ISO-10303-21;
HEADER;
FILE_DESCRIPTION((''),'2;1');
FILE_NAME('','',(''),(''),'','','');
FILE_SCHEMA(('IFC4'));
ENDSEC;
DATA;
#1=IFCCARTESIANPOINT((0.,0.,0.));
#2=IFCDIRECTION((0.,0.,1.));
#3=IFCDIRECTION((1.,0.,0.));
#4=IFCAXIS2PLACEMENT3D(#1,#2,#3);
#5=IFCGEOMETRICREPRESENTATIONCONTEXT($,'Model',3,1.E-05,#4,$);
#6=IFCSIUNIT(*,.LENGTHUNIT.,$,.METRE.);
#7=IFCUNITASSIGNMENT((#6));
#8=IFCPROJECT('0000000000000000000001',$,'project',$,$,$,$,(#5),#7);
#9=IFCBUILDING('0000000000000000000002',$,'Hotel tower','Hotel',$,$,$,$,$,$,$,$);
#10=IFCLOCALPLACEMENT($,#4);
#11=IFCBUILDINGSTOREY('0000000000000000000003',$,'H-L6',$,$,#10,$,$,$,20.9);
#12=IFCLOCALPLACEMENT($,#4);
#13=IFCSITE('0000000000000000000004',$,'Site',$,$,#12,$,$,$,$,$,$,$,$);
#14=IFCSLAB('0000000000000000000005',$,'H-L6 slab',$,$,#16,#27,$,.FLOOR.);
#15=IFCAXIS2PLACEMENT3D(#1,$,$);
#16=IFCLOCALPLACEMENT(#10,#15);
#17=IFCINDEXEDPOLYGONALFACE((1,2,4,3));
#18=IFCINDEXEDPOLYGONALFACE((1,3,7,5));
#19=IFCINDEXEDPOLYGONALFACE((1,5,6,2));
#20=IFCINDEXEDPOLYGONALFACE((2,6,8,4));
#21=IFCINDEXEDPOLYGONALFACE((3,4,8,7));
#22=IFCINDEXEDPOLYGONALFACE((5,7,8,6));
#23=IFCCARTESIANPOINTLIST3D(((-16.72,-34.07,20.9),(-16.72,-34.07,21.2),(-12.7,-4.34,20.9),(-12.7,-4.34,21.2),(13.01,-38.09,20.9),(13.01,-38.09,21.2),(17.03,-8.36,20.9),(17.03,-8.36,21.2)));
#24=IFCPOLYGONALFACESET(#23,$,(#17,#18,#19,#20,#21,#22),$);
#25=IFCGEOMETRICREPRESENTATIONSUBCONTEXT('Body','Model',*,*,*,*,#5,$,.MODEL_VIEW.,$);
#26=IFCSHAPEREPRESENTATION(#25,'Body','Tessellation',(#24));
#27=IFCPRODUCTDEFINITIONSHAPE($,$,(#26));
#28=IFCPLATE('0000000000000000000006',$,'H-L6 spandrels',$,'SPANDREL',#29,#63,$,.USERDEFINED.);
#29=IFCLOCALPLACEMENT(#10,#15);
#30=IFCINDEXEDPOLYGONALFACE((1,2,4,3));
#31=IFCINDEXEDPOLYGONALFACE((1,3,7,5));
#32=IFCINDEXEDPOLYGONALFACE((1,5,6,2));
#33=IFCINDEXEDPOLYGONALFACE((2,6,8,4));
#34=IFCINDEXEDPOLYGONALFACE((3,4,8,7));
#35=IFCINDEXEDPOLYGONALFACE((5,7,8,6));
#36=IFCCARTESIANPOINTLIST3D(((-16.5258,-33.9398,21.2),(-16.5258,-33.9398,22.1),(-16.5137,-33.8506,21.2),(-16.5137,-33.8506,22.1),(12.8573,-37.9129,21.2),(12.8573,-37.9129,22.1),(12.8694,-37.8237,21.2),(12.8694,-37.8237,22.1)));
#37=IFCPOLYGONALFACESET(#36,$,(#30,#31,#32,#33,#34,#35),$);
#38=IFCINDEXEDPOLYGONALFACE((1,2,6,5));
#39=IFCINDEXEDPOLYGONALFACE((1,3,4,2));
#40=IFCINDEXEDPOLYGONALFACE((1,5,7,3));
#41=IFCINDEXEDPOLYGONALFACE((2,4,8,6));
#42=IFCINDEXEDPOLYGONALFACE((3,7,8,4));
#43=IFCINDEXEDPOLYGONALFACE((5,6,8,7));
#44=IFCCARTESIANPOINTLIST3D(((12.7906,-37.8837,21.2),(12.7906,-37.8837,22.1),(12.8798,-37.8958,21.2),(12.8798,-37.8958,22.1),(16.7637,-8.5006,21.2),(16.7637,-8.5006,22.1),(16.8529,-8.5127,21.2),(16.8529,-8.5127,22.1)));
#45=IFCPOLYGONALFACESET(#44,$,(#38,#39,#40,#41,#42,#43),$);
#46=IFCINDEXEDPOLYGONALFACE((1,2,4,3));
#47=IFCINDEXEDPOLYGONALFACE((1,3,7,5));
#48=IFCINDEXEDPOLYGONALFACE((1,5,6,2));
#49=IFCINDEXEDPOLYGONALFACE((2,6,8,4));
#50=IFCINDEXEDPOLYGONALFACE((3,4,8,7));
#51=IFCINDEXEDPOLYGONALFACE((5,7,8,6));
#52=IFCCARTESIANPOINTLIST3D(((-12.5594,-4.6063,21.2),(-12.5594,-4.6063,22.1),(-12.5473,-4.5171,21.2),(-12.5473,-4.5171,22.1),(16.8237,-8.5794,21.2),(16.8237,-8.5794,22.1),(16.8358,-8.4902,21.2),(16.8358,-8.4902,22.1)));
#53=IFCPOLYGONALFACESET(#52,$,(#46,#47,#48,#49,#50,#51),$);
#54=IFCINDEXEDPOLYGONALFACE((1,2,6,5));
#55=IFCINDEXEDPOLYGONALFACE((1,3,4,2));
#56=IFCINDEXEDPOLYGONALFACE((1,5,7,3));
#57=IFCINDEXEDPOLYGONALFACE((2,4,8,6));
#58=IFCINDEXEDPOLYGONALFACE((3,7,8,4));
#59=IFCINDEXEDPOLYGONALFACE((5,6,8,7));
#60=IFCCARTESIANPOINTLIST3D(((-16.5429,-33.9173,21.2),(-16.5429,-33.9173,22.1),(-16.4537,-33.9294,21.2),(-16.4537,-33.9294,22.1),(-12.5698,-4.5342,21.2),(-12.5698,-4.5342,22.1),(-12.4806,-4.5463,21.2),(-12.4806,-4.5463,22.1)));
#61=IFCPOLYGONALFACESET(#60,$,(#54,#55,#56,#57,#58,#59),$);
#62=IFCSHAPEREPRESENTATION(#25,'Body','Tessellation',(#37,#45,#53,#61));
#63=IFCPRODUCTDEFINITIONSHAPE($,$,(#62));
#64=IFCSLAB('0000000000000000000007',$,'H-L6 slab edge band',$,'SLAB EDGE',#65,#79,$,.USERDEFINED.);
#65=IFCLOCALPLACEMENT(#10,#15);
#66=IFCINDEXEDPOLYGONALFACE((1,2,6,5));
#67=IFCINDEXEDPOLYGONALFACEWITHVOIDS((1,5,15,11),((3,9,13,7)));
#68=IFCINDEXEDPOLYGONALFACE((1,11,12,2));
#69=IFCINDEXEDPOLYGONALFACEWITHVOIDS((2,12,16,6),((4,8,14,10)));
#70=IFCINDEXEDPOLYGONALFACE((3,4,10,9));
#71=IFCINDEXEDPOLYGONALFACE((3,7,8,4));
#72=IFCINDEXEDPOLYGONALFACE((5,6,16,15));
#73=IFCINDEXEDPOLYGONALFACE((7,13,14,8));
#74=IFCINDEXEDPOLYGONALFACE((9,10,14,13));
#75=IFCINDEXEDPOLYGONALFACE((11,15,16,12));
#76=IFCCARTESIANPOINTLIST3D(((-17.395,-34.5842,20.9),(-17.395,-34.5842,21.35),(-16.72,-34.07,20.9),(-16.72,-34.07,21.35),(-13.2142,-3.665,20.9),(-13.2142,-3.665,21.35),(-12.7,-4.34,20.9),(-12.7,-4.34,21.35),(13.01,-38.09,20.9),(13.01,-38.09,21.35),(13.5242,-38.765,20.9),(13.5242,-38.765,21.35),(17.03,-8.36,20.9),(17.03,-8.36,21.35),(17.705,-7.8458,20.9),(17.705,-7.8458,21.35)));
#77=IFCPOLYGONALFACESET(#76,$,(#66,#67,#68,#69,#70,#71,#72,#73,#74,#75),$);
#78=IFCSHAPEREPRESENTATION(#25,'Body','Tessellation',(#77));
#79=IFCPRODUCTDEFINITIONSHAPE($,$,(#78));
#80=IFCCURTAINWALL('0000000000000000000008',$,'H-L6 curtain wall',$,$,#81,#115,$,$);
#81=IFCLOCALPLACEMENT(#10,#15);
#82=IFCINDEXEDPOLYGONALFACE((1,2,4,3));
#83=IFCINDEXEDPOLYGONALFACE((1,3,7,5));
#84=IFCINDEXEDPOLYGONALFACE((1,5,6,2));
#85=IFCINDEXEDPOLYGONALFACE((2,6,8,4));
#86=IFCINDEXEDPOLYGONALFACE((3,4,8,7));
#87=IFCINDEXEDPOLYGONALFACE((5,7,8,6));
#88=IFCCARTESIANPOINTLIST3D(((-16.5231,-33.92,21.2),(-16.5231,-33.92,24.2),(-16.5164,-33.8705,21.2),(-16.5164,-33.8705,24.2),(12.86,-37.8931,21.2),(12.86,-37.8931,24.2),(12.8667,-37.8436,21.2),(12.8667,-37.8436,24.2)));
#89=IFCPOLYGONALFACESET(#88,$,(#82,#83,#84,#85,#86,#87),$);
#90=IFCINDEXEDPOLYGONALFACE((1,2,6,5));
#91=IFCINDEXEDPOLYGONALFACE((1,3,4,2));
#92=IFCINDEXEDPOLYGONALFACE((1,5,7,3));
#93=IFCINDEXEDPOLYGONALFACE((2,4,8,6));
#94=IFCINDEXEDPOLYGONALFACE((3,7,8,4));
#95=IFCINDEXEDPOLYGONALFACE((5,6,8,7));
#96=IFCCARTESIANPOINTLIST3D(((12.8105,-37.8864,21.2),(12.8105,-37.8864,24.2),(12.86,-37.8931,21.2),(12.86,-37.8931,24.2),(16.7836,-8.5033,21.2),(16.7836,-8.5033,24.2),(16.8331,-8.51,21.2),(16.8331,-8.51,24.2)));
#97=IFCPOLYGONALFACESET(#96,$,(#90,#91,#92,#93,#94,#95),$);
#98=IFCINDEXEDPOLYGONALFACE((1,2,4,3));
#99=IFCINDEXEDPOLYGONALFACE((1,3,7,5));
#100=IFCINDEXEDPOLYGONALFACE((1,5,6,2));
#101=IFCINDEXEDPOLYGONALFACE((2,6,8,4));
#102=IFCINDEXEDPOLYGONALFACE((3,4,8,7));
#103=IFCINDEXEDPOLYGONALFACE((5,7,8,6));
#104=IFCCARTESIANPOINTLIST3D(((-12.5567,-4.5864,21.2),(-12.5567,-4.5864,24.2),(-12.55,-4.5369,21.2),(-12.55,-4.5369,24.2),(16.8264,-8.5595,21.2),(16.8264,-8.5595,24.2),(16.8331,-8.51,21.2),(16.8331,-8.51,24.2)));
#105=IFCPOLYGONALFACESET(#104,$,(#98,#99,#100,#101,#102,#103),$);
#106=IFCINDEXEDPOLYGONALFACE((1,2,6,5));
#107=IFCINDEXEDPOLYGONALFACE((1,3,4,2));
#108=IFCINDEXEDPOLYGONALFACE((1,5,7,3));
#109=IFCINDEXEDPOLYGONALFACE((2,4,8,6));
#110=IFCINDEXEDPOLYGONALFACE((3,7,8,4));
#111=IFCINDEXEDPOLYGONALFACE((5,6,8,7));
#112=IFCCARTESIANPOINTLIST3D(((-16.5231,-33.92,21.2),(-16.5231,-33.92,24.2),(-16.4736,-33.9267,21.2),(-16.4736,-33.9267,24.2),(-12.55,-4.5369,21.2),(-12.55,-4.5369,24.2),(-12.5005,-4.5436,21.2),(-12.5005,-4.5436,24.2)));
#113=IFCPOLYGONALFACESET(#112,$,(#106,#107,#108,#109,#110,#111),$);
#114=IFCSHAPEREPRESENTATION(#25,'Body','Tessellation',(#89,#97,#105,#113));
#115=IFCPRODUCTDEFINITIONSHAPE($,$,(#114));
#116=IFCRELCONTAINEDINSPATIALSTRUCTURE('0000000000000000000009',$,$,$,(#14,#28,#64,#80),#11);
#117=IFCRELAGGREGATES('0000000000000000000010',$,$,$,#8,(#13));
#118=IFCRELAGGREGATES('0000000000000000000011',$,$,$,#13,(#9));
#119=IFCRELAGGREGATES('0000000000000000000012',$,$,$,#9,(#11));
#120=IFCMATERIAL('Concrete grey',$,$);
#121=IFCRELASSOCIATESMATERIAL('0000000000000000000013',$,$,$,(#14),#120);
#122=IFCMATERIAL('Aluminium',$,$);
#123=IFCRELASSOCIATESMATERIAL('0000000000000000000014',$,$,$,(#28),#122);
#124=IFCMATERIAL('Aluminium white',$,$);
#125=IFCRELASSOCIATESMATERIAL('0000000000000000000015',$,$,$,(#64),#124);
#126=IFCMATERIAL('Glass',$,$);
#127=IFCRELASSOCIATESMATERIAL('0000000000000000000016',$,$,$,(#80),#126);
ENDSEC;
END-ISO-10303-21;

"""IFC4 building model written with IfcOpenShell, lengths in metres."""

from ifc_helpers import new_model, si_unit, frame, origin_with_axes, place, context, subcontext, project, spatial, polyline, outline, extrude, material, element, save


model = new_model("IFC4")

# Units and contexts
model_context = context("Model", 3, precision=1e-05, world=origin_with_axes())
body_context = subcontext(model_context, "Body", "Model", "MODEL_VIEW")
ifc_project = project(units=[si_unit("LENGTHUNIT", "METRE")], contexts=[model_context])

# Site, building, storey
site_placement = place(None, origin_with_axes())
site = spatial("IfcSite", under=ifc_project, at=site_placement, Name="Site")
building = spatial("IfcBuilding", under=site, Name="Hotel tower", Description="Hotel")
storey_placement = place(None, origin_with_axes())
storey = spatial("IfcBuildingStorey", under=building, at=storey_placement, Name="H-L6", Elevation=20.9)

# Shared definitions
ifc_material_1 = material(Name="Aluminium")

# Slab
ifc_material_2 = material(Name="Concrete grey")
slab_1_placement = place(storey_placement, origin_with_axes())
element("IfcSlab", 1, at=slab_1_placement, inside=storey, material=ifc_material_2, Name="H-L6 slab", PredefinedType="FLOOR", context=body_context, shape_type="SweptSolid", body=[
    extrude(outline(polyline([(-16.72, -34.07), (13.01, -38.09), (17.03, -8.36), (-12.7, -4.34), (-16.72, -34.07)])), frame((0.0, 0.0, 20.9), z_axis=(0.0, 0.0, 1.0), x_axis=(1.0, 0.0, 0.0)), (0.0, 0.0, 1.0), 0.3),
])

# Plate
plate_placement = place(storey_placement, origin_with_axes())
element("IfcPlate", 2, at=plate_placement, inside=storey, material=ifc_material_1, Name="H-L6 spandrels", ObjectType="SPANDREL", PredefinedType="USERDEFINED", context=body_context, shape_type="SweptSolid", body=[
    extrude(outline(polyline([(-16.5258, -33.9398), (12.8573, -37.9129), (12.8694, -37.8237), (-16.5137, -33.8506), (-16.5258, -33.9398)])), frame((0.0, 0.0, 21.2), z_axis=(0.0, 0.0, 1.0), x_axis=(1.0, 0.0, 0.0)), (0.0, 0.0, 1.0), 0.9),
    extrude(outline(polyline([(12.8798, -37.8958), (16.8529, -8.5127), (16.7637, -8.5006), (12.7906, -37.8837), (12.8798, -37.8958)])), frame((0.0, 0.0, 21.2), z_axis=(0.0, 0.0, 1.0), x_axis=(1.0, 0.0, 0.0)), (0.0, 0.0, 1.0), 0.9),
    extrude(outline(polyline([(16.8358, -8.4902), (-12.5473, -4.5171), (-12.5594, -4.6063), (16.8237, -8.5794), (16.8358, -8.4902)])), frame((0.0, 0.0, 21.2), z_axis=(0.0, 0.0, 1.0), x_axis=(1.0, 0.0, 0.0)), (0.0, 0.0, 1.0), 0.9),
    extrude(outline(polyline([(-12.5698, -4.5342), (-16.5429, -33.9173), (-16.4537, -33.9294), (-12.4806, -4.5463), (-12.5698, -4.5342)])), frame((0.0, 0.0, 21.2), z_axis=(0.0, 0.0, 1.0), x_axis=(1.0, 0.0, 0.0)), (0.0, 0.0, 1.0), 0.9),
])

# Slab
ifc_material_3 = material(Name="Aluminium white")
slab_2_placement = place(storey_placement, origin_with_axes())
element("IfcSlab", 3, at=slab_2_placement, inside=storey, material=ifc_material_3, Name="H-L6 slab edge band", ObjectType="SLAB EDGE", PredefinedType="USERDEFINED", context=body_context, shape_type="SweptSolid", body=[
    extrude(outline(polyline([(-17.395, -34.5842), (13.5242, -38.765), (17.705, -7.8458), (-13.2142, -3.665), (-17.395, -34.5842)]), holes=[polyline([(-16.72, -34.07), (13.01, -38.09), (17.03, -8.36), (-12.7, -4.34), (-16.72, -34.07)])]), frame((0.0, 0.0, 20.9), z_axis=(0.0, 0.0, 1.0), x_axis=(1.0, 0.0, 0.0)), (0.0, 0.0, 1.0), 0.45),
])

# Curtain wall
ifc_material_4 = material(Name="Glass")
curtain_wall_placement = place(storey_placement, origin_with_axes())
element("IfcCurtainWall", 4, at=curtain_wall_placement, inside=storey, material=ifc_material_4, Name="H-L6 curtain wall", context=body_context, shape_type="SweptSolid", body=[
    extrude(outline(polyline([(-16.5231, -33.92), (12.86, -37.8931), (12.8667, -37.8436), (-16.5164, -33.8705), (-16.5231, -33.92)])), frame((0.0, 0.0, 21.2), z_axis=(0.0, 0.0, 1.0), x_axis=(1.0, 0.0, 0.0)), (0.0, 0.0, 1.0), 3.0),
    extrude(outline(polyline([(12.86, -37.8931), (16.8331, -8.51), (16.7836, -8.5033), (12.8105, -37.8864), (12.86, -37.8931)])), frame((0.0, 0.0, 21.2), z_axis=(0.0, 0.0, 1.0), x_axis=(1.0, 0.0, 0.0)), (0.0, 0.0, 1.0), 3.0),
    extrude(outline(polyline([(16.8331, -8.51), (-12.55, -4.5369), (-12.5567, -4.5864), (16.8264, -8.5595), (16.8331, -8.51)])), frame((0.0, 0.0, 21.2), z_axis=(0.0, 0.0, 1.0), x_axis=(1.0, 0.0, 0.0)), (0.0, 0.0, 1.0), 3.0),
    extrude(outline(polyline([(-12.55, -4.5369), (-16.5231, -33.92), (-16.4736, -33.9267), (-12.5005, -4.5436), (-12.55, -4.5369)])), frame((0.0, 0.0, 21.2), z_axis=(0.0, 0.0, 1.0), x_axis=(1.0, 0.0, 0.0)), (0.0, 0.0, 1.0), 3.0),
])

save(model, "model.ifc")
